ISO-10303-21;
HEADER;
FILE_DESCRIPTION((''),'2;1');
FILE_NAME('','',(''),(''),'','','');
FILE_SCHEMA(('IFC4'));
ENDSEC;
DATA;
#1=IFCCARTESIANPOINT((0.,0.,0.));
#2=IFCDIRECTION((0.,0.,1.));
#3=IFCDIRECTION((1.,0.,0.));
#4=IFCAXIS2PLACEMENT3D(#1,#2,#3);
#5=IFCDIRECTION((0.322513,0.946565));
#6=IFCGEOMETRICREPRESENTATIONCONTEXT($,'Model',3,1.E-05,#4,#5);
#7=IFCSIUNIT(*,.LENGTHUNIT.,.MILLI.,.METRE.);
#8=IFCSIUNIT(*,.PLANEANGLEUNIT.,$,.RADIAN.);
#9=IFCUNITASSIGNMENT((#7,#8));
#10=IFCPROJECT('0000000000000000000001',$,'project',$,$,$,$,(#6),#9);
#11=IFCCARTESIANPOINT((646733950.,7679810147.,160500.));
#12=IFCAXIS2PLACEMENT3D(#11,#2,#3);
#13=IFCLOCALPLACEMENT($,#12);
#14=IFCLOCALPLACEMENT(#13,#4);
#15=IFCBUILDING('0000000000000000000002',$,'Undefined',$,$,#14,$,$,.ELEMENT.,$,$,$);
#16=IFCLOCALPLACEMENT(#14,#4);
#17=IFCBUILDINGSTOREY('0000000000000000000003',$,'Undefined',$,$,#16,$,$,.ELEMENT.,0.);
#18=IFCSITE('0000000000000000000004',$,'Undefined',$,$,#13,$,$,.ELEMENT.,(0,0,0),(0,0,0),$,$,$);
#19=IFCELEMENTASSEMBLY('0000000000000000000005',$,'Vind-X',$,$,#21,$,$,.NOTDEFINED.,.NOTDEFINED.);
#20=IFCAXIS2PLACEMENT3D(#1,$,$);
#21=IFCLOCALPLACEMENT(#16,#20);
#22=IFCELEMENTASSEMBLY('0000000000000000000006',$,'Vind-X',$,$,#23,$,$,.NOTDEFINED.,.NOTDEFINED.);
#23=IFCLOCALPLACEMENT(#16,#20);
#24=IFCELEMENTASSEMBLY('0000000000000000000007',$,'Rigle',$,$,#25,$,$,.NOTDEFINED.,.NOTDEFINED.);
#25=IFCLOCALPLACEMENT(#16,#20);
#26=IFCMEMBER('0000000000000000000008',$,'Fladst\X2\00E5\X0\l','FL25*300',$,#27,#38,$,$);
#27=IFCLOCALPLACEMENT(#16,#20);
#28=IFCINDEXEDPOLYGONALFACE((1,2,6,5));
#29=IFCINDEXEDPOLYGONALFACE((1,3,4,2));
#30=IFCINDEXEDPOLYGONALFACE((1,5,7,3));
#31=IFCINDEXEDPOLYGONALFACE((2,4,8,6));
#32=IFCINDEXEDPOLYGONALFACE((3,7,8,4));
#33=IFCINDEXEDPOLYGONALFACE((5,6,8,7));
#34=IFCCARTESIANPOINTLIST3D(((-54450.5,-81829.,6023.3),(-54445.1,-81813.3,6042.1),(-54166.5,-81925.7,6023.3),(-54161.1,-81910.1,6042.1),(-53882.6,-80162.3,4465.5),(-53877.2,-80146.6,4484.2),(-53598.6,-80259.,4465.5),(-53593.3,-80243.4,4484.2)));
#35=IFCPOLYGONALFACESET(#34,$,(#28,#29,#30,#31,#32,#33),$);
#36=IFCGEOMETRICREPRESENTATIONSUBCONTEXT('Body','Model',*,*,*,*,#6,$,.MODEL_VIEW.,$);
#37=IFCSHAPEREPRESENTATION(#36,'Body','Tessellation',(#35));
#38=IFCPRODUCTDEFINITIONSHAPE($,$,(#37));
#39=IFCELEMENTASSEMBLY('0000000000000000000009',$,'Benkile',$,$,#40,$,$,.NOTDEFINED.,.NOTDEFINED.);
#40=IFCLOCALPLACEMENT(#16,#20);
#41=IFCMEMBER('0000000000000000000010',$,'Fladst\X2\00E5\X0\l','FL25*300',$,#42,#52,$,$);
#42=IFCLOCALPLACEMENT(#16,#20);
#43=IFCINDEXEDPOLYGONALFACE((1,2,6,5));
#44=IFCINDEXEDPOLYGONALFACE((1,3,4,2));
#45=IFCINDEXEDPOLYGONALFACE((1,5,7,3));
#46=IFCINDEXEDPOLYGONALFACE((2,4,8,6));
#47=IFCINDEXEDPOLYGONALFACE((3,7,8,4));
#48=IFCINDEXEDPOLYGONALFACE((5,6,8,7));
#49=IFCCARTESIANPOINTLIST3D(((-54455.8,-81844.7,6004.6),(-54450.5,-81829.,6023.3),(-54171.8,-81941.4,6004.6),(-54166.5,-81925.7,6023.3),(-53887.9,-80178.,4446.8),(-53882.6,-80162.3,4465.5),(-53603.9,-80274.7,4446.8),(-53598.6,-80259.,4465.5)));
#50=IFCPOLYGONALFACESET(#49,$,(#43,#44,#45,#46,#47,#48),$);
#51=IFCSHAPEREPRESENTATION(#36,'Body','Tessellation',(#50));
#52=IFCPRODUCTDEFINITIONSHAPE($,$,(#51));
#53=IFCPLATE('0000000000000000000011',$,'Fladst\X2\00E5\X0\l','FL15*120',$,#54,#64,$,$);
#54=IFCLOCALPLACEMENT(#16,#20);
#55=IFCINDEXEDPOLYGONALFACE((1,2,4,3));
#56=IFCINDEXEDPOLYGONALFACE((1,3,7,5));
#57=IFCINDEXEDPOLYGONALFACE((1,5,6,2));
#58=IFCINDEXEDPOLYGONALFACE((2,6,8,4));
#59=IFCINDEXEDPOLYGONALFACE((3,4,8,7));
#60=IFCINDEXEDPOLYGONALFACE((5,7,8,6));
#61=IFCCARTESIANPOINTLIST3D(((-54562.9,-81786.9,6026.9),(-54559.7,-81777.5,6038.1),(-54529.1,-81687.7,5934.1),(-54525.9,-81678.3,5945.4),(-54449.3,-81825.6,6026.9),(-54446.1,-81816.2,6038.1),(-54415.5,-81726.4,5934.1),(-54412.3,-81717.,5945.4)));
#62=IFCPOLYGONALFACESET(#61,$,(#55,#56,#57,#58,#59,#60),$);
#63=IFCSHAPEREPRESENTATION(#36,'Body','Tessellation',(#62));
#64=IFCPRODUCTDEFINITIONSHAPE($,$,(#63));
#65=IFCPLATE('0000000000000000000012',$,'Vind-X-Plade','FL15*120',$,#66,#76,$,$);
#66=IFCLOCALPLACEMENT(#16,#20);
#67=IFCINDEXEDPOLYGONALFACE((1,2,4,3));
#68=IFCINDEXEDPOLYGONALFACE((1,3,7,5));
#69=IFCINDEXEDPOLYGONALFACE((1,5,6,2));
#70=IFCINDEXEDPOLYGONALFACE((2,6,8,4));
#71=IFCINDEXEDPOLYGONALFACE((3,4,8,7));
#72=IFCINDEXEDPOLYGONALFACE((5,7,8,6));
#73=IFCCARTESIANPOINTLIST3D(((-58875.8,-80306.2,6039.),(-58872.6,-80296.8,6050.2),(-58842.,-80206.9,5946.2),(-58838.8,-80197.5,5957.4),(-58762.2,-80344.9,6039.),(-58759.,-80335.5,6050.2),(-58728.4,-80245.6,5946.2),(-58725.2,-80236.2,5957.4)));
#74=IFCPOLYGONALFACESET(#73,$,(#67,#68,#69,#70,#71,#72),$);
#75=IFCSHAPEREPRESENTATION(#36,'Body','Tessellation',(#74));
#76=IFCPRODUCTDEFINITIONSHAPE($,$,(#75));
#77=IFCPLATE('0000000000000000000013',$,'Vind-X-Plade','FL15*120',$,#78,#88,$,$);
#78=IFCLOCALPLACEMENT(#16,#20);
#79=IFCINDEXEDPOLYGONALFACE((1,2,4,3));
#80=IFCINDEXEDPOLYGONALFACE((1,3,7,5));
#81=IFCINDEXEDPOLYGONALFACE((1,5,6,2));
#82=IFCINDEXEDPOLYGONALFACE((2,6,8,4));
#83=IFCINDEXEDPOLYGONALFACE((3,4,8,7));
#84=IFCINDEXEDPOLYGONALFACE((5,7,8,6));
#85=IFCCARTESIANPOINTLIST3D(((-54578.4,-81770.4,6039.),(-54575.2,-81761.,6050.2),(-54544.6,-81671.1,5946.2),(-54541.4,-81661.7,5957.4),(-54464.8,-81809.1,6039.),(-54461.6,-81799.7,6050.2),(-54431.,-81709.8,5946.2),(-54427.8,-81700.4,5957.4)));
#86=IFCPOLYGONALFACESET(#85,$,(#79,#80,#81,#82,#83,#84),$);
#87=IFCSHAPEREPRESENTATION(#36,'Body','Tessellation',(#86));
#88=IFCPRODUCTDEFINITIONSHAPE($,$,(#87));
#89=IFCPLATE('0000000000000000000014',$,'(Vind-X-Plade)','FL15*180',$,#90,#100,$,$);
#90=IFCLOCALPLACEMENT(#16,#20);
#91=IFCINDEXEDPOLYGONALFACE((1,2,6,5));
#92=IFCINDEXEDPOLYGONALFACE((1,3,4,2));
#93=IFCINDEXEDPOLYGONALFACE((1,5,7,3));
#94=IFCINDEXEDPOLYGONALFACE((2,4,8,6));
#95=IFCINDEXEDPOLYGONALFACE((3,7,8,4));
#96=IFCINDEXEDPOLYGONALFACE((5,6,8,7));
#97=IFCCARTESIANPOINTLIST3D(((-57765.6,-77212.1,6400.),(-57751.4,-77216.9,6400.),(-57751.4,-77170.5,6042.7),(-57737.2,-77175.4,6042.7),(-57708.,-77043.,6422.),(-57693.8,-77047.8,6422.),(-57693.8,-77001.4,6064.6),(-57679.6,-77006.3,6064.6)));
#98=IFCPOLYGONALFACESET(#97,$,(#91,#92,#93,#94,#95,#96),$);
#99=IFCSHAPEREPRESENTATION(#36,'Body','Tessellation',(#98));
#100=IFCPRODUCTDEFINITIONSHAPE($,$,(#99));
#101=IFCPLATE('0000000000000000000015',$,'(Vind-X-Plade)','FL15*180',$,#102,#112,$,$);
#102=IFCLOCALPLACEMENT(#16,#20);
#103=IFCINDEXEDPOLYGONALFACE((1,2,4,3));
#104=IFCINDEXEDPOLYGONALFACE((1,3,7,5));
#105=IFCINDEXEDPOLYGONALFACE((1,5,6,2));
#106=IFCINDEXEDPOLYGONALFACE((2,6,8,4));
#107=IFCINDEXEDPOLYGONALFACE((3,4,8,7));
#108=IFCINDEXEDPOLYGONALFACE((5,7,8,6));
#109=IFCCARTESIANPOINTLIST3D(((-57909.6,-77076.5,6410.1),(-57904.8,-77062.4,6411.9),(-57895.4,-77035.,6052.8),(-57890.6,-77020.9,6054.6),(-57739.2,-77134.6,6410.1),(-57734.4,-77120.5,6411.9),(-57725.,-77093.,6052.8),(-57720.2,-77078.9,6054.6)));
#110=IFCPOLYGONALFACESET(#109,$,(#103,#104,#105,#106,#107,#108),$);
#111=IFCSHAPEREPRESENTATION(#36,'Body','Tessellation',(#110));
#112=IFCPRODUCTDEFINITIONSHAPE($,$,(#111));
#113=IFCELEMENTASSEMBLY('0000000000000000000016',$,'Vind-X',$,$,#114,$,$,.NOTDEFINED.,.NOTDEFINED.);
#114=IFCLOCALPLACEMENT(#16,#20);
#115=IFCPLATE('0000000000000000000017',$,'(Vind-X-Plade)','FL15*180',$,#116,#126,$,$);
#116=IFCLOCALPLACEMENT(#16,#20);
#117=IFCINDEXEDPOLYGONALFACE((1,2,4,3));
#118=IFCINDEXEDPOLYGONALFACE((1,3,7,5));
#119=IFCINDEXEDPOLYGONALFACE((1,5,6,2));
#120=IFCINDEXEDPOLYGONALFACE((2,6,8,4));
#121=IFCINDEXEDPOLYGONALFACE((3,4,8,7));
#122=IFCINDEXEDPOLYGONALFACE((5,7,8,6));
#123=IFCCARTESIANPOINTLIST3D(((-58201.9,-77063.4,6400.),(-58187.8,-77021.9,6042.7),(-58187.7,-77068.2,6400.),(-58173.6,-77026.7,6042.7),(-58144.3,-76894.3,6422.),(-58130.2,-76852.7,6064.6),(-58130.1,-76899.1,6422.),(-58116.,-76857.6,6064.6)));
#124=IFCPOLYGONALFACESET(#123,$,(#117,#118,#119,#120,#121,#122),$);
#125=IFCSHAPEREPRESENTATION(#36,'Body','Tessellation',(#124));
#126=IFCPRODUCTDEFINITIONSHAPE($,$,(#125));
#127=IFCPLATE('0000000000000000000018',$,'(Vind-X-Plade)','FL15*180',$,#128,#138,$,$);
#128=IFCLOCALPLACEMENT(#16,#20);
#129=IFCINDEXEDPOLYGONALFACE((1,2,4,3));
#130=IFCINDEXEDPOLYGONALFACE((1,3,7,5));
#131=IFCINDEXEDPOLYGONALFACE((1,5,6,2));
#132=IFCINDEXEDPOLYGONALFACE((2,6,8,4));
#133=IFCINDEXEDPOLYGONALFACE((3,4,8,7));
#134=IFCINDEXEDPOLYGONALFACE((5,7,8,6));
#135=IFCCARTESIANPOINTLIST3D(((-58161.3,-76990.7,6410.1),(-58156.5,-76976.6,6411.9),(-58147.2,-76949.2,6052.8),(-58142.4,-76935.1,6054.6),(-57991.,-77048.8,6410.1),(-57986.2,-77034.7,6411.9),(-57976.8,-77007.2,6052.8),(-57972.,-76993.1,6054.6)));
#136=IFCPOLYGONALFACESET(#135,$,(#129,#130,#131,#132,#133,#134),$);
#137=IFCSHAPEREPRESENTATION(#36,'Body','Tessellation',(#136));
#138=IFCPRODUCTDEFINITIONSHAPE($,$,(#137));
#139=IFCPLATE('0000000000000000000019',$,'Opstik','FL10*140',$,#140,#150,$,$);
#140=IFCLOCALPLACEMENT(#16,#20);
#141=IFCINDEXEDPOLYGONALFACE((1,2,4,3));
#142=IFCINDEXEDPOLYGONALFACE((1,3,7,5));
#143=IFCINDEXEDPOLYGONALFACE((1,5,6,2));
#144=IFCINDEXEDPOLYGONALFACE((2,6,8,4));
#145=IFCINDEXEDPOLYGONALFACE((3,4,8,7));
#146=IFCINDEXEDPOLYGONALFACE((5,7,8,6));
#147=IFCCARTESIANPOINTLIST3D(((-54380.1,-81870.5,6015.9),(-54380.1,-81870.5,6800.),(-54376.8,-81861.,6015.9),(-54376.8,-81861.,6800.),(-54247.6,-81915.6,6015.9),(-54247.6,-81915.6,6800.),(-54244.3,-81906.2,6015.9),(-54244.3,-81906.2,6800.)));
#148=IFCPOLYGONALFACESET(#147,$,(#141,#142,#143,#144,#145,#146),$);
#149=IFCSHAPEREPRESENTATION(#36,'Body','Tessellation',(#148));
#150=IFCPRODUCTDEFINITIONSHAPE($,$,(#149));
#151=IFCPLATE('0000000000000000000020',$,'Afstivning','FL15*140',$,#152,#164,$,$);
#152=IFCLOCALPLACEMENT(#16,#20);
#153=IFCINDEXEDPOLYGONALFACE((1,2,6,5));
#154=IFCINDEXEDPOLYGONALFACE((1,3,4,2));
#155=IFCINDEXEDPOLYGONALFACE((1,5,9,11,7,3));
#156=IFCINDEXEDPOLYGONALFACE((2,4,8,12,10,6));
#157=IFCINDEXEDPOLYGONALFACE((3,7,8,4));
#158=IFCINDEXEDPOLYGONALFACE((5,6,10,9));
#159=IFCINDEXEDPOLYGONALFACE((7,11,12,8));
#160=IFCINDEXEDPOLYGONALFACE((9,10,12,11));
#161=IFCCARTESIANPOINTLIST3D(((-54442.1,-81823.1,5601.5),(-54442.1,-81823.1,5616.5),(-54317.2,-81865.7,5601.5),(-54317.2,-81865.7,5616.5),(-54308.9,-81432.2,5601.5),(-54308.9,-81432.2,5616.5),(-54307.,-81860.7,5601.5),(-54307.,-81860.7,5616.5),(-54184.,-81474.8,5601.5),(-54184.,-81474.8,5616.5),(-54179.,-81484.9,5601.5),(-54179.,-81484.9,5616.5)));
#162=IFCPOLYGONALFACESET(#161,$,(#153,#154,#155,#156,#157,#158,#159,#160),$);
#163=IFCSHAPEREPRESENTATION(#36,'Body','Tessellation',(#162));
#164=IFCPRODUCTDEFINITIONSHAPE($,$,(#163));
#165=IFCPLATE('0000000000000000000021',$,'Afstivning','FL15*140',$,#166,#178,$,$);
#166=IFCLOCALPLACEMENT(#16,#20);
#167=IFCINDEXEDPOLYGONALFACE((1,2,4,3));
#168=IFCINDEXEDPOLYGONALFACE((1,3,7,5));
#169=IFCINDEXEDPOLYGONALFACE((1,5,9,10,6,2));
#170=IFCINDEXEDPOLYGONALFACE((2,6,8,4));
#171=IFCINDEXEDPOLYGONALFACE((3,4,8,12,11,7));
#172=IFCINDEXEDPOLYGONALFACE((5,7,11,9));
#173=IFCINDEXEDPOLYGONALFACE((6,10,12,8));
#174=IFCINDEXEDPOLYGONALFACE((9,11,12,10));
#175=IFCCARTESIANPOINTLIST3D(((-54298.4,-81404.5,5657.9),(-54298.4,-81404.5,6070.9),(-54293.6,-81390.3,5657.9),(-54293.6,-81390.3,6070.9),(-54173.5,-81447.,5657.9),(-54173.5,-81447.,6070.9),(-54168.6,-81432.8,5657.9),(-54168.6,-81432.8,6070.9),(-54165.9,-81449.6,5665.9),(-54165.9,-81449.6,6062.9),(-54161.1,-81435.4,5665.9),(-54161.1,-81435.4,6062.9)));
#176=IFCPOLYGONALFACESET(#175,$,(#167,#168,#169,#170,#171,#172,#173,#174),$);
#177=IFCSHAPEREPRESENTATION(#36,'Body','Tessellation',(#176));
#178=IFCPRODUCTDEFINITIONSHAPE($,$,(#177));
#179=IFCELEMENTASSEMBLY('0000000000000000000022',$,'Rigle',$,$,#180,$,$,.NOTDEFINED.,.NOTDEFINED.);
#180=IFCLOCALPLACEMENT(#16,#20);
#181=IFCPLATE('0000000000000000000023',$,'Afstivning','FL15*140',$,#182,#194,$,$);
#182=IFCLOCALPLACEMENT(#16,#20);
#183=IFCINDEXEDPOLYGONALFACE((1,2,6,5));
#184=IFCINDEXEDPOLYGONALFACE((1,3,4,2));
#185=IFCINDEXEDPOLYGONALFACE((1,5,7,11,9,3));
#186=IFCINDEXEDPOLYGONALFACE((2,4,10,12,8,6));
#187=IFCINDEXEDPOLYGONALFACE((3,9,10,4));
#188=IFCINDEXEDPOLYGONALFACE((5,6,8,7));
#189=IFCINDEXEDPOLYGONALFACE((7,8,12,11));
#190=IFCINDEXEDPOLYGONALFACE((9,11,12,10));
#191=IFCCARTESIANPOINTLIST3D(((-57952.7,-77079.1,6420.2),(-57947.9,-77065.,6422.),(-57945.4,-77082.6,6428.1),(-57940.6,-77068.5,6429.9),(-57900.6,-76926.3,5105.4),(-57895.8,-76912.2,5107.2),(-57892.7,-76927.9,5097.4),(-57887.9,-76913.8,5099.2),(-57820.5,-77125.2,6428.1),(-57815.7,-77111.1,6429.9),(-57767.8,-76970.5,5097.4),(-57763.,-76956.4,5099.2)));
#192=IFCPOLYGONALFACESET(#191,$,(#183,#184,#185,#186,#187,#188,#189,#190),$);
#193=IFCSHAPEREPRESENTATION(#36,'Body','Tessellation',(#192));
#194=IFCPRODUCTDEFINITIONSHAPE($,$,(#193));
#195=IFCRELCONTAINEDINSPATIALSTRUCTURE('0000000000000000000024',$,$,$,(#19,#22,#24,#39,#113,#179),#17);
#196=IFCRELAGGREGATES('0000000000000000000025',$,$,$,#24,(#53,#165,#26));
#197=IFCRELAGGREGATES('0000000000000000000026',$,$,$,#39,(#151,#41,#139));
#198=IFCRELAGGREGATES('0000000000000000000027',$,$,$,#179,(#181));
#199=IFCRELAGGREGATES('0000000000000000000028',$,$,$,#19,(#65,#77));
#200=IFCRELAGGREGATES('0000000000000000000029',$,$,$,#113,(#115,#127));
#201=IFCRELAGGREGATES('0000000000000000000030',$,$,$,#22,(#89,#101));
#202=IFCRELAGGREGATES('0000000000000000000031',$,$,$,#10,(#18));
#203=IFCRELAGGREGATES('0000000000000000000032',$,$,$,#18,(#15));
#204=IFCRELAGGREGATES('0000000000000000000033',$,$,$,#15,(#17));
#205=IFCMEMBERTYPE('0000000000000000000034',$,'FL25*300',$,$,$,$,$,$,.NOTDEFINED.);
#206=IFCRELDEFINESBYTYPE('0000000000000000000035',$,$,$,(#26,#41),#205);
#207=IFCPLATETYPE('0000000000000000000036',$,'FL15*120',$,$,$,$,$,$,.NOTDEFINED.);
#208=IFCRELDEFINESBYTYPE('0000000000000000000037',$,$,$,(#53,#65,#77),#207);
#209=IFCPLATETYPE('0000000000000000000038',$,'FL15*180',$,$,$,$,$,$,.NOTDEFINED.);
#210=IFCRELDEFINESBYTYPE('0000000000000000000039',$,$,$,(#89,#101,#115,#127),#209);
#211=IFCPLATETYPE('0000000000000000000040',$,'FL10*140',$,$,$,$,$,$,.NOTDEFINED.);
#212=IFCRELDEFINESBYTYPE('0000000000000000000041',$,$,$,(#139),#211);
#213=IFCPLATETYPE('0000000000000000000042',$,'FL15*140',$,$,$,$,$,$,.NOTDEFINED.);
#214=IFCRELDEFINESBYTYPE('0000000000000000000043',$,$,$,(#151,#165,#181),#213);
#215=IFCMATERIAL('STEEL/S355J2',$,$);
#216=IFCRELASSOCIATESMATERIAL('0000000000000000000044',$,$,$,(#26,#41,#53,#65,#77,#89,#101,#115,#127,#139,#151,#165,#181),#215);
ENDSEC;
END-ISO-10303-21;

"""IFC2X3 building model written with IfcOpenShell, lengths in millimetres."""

from ifc_helpers import new_model, si_unit, direction, frame, origin_with_axes, origin_2d_with_axis, place, context, subcontext, project, spatial, polyline, rectangle, outline, extrude, material, type_object, element, aggregate, save


model = new_model("IFC2X3")

# Units and contexts
model_context = context("Model", 3, precision=1e-05, world=origin_with_axes(), true_north=direction((0.322513, 0.946565)))
body_context = subcontext(model_context, "Body", "Model", "MODEL_VIEW")
ifc_project = project(units=[si_unit("LENGTHUNIT", "METRE", prefix="MILLI"), si_unit("PLANEANGLEUNIT", "RADIAN")], contexts=[model_context])

# Site, building, storey
site_placement = place(None, frame((646733950.0, 7679810147.0, 160500.0), z_axis=(0.0, 0.0, 1.0), x_axis=(1.0, 0.0, 0.0)))
site = spatial("IfcSite", under=ifc_project, at=site_placement, Name="Undefined", CompositionType="ELEMENT", RefLatitude=(0, 0, 0), RefLongitude=(0, 0, 0))
building_placement = place(site_placement, origin_with_axes())
building = spatial("IfcBuilding", under=site, at=building_placement, Name="Undefined", CompositionType="ELEMENT")
storey_placement = place(building_placement, origin_with_axes())
storey = spatial("IfcBuildingStorey", under=building, at=storey_placement, Name="Undefined", CompositionType="ELEMENT", Elevation=0.0)

# Element assembly
assembly_1_placement = place(storey_placement, origin_with_axes())
assembly_1 = element("IfcElementAssembly", 1, at=assembly_1_placement, inside=storey, Name="Vind-X", AssemblyPlace="NOTDEFINED", PredefinedType="NOTDEFINED")

# Shared definitions
ifc_material_1 = material(Name="STEEL/S355J2")

# Element assembly
assembly_2_placement = place(storey_placement, origin_with_axes())
assembly_2 = element("IfcElementAssembly", 2, at=assembly_2_placement, inside=storey, Name="Vind-X", AssemblyPlace="NOTDEFINED", PredefinedType="NOTDEFINED")

# Element assemblies, members
assembly_3_placement = place(storey_placement, origin_with_axes())
assembly_3 = element("IfcElementAssembly", 3, at=assembly_3_placement, inside=storey, Name="Rigle", AssemblyPlace="NOTDEFINED", PredefinedType="NOTDEFINED")
member_type_1 = type_object("IfcMemberType", Name="FL25*300", PredefinedType="NOTDEFINED")
member_1_placement = place(assembly_3_placement, frame((-54305.8, -81869.5, 6032.7), z_axis=(0.946565, -0.322513, 0.0), x_axis=(0.241548, 0.708935, -0.66262)))
member_1 = element("IfcMember", 4, at=member_1_placement, type_object=member_type_1, material=ifc_material_1, Name="Fladstål", Description="FL25*300", context=body_context, shape_type="SweptSolid", body=[
    extrude(rectangle(XDim=25.0, YDim=300.0, at=origin_2d_with_axis()), frame((2351.0, 0.0, 0.0), z_axis=(-1.0, 0.0, 0.0), x_axis=(0.0, -1.0, 0.0)), (0.0, 0.0, 1.0), 2351.0),
])
assembly_4_placement = place(storey_placement, origin_with_axes())
assembly_4 = element("IfcElementAssembly", 5, at=assembly_4_placement, inside=storey, Name="Benkile", AssemblyPlace="NOTDEFINED", PredefinedType="NOTDEFINED")
member_2_placement = place(assembly_4_placement, frame((-54311.1, -81885.2, 6014.0), z_axis=(0.946565, -0.322513, 0.0), x_axis=(0.241548, 0.708935, -0.66262)))
member_2 = element("IfcMember", 6, at=member_2_placement, type_object=member_type_1, material=ifc_material_1, Name="Fladstål", Description="FL25*300", context=body_context, shape_type="SweptSolid", body=[
    extrude(rectangle(XDim=25.0, YDim=300.0, at=origin_2d_with_axis()), frame((2351.0, 0.0, 0.0), z_axis=(-1.0, 0.0, 0.0), x_axis=(0.0, -1.0, 0.0)), (0.0, 0.0, 1.0), 2351.0),
])

# Plates
plate_type_1 = type_object("IfcPlateType", Name="FL15*120", PredefinedType="NOTDEFINED")
plate_1_placement = place(assembly_3_placement, frame((-54413.9, -81721.7, 5939.7), z_axis=(-0.213703, -0.627213, -0.748956), x_axis=(-0.241548, -0.708935, 0.66262)))
plate_1 = element("IfcPlate", 7, at=plate_1_placement, type_object=plate_type_1, material=ifc_material_1, Name="Fladstål", Description="FL15*120", context=body_context, shape_type="SweptSolid", body=[
    extrude(outline(polyline([(0.0, 0.0), (140.0, 0.0), (140.0, 120.0), (0.0, 120.0), (0.0, 0.0)])), frame((0.0, 0.0, -7.5), z_axis=(0.0, 0.0, 1.0), x_axis=(1.0, 0.0, 0.0)), (0.0, 0.0, 1.0), 15.0),
])
plate_2_placement = place(assembly_1_placement, frame((-58857.3, -80251.8, 5998.2), z_axis=(-0.213703, -0.627213, -0.748956), x_axis=(0.946565, -0.322513, 0.0)))
plate_2 = element("IfcPlate", 8, at=plate_2_placement, type_object=plate_type_1, material=ifc_material_1, Name="Vind-X-Plade", Description="FL15*120", context=body_context, shape_type="SweptSolid", body=[
    extrude(outline(polyline([(0.0, -70.0), (0.0, 70.0), (120.0, 70.0), (120.0, -70.0), (0.0, -70.0)])), frame((0.0, 0.0, -7.5), z_axis=(0.0, 0.0, 1.0), x_axis=(1.0, 0.0, 0.0)), (0.0, 0.0, 1.0), 15.0),
])
plate_3_placement = place(assembly_1_placement, frame((-54446.3, -81754.8, 5998.2), z_axis=(0.213703, 0.627213, 0.748956), x_axis=(-0.946565, 0.322513, 0.0)))
plate_3 = element("IfcPlate", 9, at=plate_3_placement, type_object=plate_type_1, material=ifc_material_1, Name="Vind-X-Plade", Description="FL15*120", context=body_context, shape_type="SweptSolid", body=[
    extrude(outline(polyline([(0.0, -70.0), (0.0, 70.0), (120.0, 70.0), (120.0, -70.0), (0.0, -70.0)])), frame((0.0, 0.0, -7.5), z_axis=(0.0, 0.0, 1.0), x_axis=(1.0, 0.0, 0.0)), (0.0, 0.0, 1.0), 15.0),
])
plate_type_2 = type_object("IfcPlateType", Name="FL15*180", PredefinedType="NOTDEFINED")
plate_4_placement = place(assembly_2_placement, frame((-57758.5, -77214.5, 6400.0), z_axis=(-0.946565, 0.322513, 0.0), x_axis=(0.320109, 0.93951, 0.121869)))
plate_4 = element("IfcPlate", 10, at=plate_4_placement, type_object=plate_type_2, material=ifc_material_1, Name="(Vind-X-Plade)", Description="FL15*180", context=body_context, shape_type="SweptSolid", body=[
    extrude(outline(polyline([(0.0, 0.0), (180.0, 0.0), (180.0, 360.0), (0.0, 360.0), (0.0, 0.0)])), frame((0.0, 0.0, -7.5), z_axis=(0.0, 0.0, 1.0), x_axis=(1.0, 0.0, 0.0)), (0.0, 0.0, 1.0), 15.0),
])
plate_5_placement = place(assembly_2_placement, frame((-57893.0, -77027.9, 6053.7), z_axis=(0.320109, 0.93951, 0.121869), x_axis=(-0.039304, -0.115357, 0.992546)))
plate_5 = element("IfcPlate", 11, at=plate_5_placement, type_object=plate_type_2, material=ifc_material_1, Name="(Vind-X-Plade)", Description="FL15*180", context=body_context, shape_type="SweptSolid", body=[
    extrude(outline(polyline([(0.0, 0.0), (360.0, 0.0), (360.0, 180.0), (0.0, 180.0), (0.0, 0.0)])), frame((0.0, 0.0, -7.5), z_axis=(0.0, 0.0, 1.0), x_axis=(1.0, 0.0, 0.0)), (0.0, 0.0, 1.0), 15.0),
])

# Element assembly, plates
assembly_5_placement = place(storey_placement, origin_with_axes())
assembly_5 = element("IfcElementAssembly", 12, at=assembly_5_placement, inside=storey, Name="Vind-X", AssemblyPlace="NOTDEFINED", PredefinedType="NOTDEFINED")
plate_6_placement = place(assembly_5_placement, frame((-58137.2, -76896.7, 6422.0), z_axis=(0.946565, -0.322513, 0.0), x_axis=(-0.320109, -0.93951, -0.121869)))
plate_6 = element("IfcPlate", 13, at=plate_6_placement, type_object=plate_type_2, material=ifc_material_1, Name="(Vind-X-Plade)", Description="FL15*180", context=body_context, shape_type="SweptSolid", body=[
    extrude(outline(polyline([(0.0, 0.0), (180.0, 0.0), (180.0, 360.0), (0.0, 360.0), (0.0, 0.0)])), frame((0.0, 0.0, -7.5), z_axis=(0.0, 0.0, 1.0), x_axis=(1.0, 0.0, 0.0)), (0.0, 0.0, 1.0), 15.0),
])
plate_7_placement = place(assembly_5_placement, frame((-57974.4, -77000.2, 6053.7), z_axis=(-0.320109, -0.93951, -0.121869), x_axis=(-0.039304, -0.115357, 0.992546)))
plate_7 = element("IfcPlate", 14, at=plate_7_placement, type_object=plate_type_2, material=ifc_material_1, Name="(Vind-X-Plade)", Description="FL15*180", context=body_context, shape_type="SweptSolid", body=[
    extrude(outline(polyline([(0.0, 0.0), (360.0, 0.0), (360.0, 180.0), (0.0, 180.0), (0.0, 0.0)])), frame((0.0, 0.0, -7.5), z_axis=(0.0, 0.0, 1.0), x_axis=(1.0, 0.0, 0.0)), (0.0, 0.0, 1.0), 15.0),
])

# Plates
plate_type_3 = type_object("IfcPlateType", Name="FL10*140", PredefinedType="NOTDEFINED")
plate_8_placement = place(assembly_4_placement, frame((-54245.9, -81910.9, 6015.9), z_axis=(-0.322513, -0.946565, 0.0), x_axis=(0.0, 0.0, 1.0)))
plate_8 = element("IfcPlate", 15, at=plate_8_placement, type_object=plate_type_3, material=ifc_material_1, Name="Opstik", Description="FL10*140", context=body_context, shape_type="SweptSolid", body=[
    extrude(outline(polyline([(0.0, 0.0), (784.1, 0.0), (784.1, 0.0), (784.1, 140.0), (784.1, 140.0), (0.0, 140.0), (0.0, 0.0)])), frame((0.0, 0.0, -5.0), z_axis=(0.0, 0.0, 1.0), x_axis=(1.0, 0.0, 0.0)), (0.0, 0.0, 1.0), 10.0),
])
plate_type_4 = type_object("IfcPlateType", Name="FL15*140", PredefinedType="NOTDEFINED")
plate_9_placement = place(assembly_4_placement, frame((-54308.9, -81432.2, 5609.0), z_axis=(0.0, 0.0, -1.0), x_axis=(0.946565, -0.322513, 0.0)))
plate_9 = element("IfcPlate", 16, at=plate_9_placement, type_object=plate_type_4, material=ifc_material_1, Name="Afstivning", Description="FL15*140", context=body_context, shape_type="SweptSolid", body=[
    extrude(outline(polyline([(0.0, 0.0), (132.0, 0.0), (140.0, 8.0), (140.0, 405.0), (132.0, 413.0), (0.0, 413.0), (0.0, 0.0)])), frame((0.0, 0.0, -7.5), z_axis=(0.0, 0.0, 1.0), x_axis=(1.0, 0.0, 0.0)), (0.0, 0.0, 1.0), 15.0),
])
plate_10_placement = place(assembly_3_placement, frame((-54296.0, -81397.4, 5657.9), z_axis=(-0.322513, -0.946565, 0.0), x_axis=(0.946565, -0.322513, 0.0)))
plate_10 = element("IfcPlate", 17, at=plate_10_placement, type_object=plate_type_4, material=ifc_material_1, Name="Afstivning", Description="FL15*140", context=body_context, shape_type="SweptSolid", body=[
    extrude(outline(polyline([(0.0, 0.0), (132.0, 0.0), (140.0, 8.0), (140.0, 405.0), (132.0, 413.0), (0.0, 413.0), (0.0, 0.0)])), frame((0.0, 0.0, -7.5), z_axis=(0.0, 0.0, 1.0), x_axis=(1.0, 0.0, 0.0)), (0.0, 0.0, 1.0), 15.0),
])

# Element assembly, plate
assembly_6_placement = place(storey_placement, origin_with_axes())
assembly_6 = element("IfcElementAssembly", 18, at=assembly_6_placement, inside=storey, Name="Rigle", AssemblyPlace="NOTDEFINED", PredefinedType="NOTDEFINED")
plate_11_placement = place(assembly_6_placement, frame((-57765.4, -76963.5, 5098.3), z_axis=(0.320109, 0.93951, 0.121869), x_axis=(-0.946565, 0.322513, 0.0)))
plate_11 = element("IfcPlate", 19, at=plate_11_placement, type_object=plate_type_4, material=ifc_material_1, Name="Afstivning", Description="FL15*140", context=body_context, shape_type="SweptSolid", body=[
    extrude(outline(polyline([(0.0, 0.0), (132.0, 0.0), (140.0, 8.0), (140.0, 1332.7), (132.0, 1340.7), (0.0, 1340.7), (0.0, 0.0)])), frame((0.0, 0.0, -7.5), z_axis=(0.0, 0.0, 1.0), x_axis=(1.0, 0.0, 0.0)), (0.0, 0.0, 1.0), 15.0),
])

aggregate(assembly_3, [plate_1, plate_10, member_1])

aggregate(assembly_4, [plate_9, member_2, plate_8])

aggregate(assembly_6, [plate_11])

aggregate(assembly_1, [plate_2, plate_3])
aggregate(assembly_5, [plate_6, plate_7])
aggregate(assembly_2, [plate_4, plate_5])

save(model, "model.ifc")
